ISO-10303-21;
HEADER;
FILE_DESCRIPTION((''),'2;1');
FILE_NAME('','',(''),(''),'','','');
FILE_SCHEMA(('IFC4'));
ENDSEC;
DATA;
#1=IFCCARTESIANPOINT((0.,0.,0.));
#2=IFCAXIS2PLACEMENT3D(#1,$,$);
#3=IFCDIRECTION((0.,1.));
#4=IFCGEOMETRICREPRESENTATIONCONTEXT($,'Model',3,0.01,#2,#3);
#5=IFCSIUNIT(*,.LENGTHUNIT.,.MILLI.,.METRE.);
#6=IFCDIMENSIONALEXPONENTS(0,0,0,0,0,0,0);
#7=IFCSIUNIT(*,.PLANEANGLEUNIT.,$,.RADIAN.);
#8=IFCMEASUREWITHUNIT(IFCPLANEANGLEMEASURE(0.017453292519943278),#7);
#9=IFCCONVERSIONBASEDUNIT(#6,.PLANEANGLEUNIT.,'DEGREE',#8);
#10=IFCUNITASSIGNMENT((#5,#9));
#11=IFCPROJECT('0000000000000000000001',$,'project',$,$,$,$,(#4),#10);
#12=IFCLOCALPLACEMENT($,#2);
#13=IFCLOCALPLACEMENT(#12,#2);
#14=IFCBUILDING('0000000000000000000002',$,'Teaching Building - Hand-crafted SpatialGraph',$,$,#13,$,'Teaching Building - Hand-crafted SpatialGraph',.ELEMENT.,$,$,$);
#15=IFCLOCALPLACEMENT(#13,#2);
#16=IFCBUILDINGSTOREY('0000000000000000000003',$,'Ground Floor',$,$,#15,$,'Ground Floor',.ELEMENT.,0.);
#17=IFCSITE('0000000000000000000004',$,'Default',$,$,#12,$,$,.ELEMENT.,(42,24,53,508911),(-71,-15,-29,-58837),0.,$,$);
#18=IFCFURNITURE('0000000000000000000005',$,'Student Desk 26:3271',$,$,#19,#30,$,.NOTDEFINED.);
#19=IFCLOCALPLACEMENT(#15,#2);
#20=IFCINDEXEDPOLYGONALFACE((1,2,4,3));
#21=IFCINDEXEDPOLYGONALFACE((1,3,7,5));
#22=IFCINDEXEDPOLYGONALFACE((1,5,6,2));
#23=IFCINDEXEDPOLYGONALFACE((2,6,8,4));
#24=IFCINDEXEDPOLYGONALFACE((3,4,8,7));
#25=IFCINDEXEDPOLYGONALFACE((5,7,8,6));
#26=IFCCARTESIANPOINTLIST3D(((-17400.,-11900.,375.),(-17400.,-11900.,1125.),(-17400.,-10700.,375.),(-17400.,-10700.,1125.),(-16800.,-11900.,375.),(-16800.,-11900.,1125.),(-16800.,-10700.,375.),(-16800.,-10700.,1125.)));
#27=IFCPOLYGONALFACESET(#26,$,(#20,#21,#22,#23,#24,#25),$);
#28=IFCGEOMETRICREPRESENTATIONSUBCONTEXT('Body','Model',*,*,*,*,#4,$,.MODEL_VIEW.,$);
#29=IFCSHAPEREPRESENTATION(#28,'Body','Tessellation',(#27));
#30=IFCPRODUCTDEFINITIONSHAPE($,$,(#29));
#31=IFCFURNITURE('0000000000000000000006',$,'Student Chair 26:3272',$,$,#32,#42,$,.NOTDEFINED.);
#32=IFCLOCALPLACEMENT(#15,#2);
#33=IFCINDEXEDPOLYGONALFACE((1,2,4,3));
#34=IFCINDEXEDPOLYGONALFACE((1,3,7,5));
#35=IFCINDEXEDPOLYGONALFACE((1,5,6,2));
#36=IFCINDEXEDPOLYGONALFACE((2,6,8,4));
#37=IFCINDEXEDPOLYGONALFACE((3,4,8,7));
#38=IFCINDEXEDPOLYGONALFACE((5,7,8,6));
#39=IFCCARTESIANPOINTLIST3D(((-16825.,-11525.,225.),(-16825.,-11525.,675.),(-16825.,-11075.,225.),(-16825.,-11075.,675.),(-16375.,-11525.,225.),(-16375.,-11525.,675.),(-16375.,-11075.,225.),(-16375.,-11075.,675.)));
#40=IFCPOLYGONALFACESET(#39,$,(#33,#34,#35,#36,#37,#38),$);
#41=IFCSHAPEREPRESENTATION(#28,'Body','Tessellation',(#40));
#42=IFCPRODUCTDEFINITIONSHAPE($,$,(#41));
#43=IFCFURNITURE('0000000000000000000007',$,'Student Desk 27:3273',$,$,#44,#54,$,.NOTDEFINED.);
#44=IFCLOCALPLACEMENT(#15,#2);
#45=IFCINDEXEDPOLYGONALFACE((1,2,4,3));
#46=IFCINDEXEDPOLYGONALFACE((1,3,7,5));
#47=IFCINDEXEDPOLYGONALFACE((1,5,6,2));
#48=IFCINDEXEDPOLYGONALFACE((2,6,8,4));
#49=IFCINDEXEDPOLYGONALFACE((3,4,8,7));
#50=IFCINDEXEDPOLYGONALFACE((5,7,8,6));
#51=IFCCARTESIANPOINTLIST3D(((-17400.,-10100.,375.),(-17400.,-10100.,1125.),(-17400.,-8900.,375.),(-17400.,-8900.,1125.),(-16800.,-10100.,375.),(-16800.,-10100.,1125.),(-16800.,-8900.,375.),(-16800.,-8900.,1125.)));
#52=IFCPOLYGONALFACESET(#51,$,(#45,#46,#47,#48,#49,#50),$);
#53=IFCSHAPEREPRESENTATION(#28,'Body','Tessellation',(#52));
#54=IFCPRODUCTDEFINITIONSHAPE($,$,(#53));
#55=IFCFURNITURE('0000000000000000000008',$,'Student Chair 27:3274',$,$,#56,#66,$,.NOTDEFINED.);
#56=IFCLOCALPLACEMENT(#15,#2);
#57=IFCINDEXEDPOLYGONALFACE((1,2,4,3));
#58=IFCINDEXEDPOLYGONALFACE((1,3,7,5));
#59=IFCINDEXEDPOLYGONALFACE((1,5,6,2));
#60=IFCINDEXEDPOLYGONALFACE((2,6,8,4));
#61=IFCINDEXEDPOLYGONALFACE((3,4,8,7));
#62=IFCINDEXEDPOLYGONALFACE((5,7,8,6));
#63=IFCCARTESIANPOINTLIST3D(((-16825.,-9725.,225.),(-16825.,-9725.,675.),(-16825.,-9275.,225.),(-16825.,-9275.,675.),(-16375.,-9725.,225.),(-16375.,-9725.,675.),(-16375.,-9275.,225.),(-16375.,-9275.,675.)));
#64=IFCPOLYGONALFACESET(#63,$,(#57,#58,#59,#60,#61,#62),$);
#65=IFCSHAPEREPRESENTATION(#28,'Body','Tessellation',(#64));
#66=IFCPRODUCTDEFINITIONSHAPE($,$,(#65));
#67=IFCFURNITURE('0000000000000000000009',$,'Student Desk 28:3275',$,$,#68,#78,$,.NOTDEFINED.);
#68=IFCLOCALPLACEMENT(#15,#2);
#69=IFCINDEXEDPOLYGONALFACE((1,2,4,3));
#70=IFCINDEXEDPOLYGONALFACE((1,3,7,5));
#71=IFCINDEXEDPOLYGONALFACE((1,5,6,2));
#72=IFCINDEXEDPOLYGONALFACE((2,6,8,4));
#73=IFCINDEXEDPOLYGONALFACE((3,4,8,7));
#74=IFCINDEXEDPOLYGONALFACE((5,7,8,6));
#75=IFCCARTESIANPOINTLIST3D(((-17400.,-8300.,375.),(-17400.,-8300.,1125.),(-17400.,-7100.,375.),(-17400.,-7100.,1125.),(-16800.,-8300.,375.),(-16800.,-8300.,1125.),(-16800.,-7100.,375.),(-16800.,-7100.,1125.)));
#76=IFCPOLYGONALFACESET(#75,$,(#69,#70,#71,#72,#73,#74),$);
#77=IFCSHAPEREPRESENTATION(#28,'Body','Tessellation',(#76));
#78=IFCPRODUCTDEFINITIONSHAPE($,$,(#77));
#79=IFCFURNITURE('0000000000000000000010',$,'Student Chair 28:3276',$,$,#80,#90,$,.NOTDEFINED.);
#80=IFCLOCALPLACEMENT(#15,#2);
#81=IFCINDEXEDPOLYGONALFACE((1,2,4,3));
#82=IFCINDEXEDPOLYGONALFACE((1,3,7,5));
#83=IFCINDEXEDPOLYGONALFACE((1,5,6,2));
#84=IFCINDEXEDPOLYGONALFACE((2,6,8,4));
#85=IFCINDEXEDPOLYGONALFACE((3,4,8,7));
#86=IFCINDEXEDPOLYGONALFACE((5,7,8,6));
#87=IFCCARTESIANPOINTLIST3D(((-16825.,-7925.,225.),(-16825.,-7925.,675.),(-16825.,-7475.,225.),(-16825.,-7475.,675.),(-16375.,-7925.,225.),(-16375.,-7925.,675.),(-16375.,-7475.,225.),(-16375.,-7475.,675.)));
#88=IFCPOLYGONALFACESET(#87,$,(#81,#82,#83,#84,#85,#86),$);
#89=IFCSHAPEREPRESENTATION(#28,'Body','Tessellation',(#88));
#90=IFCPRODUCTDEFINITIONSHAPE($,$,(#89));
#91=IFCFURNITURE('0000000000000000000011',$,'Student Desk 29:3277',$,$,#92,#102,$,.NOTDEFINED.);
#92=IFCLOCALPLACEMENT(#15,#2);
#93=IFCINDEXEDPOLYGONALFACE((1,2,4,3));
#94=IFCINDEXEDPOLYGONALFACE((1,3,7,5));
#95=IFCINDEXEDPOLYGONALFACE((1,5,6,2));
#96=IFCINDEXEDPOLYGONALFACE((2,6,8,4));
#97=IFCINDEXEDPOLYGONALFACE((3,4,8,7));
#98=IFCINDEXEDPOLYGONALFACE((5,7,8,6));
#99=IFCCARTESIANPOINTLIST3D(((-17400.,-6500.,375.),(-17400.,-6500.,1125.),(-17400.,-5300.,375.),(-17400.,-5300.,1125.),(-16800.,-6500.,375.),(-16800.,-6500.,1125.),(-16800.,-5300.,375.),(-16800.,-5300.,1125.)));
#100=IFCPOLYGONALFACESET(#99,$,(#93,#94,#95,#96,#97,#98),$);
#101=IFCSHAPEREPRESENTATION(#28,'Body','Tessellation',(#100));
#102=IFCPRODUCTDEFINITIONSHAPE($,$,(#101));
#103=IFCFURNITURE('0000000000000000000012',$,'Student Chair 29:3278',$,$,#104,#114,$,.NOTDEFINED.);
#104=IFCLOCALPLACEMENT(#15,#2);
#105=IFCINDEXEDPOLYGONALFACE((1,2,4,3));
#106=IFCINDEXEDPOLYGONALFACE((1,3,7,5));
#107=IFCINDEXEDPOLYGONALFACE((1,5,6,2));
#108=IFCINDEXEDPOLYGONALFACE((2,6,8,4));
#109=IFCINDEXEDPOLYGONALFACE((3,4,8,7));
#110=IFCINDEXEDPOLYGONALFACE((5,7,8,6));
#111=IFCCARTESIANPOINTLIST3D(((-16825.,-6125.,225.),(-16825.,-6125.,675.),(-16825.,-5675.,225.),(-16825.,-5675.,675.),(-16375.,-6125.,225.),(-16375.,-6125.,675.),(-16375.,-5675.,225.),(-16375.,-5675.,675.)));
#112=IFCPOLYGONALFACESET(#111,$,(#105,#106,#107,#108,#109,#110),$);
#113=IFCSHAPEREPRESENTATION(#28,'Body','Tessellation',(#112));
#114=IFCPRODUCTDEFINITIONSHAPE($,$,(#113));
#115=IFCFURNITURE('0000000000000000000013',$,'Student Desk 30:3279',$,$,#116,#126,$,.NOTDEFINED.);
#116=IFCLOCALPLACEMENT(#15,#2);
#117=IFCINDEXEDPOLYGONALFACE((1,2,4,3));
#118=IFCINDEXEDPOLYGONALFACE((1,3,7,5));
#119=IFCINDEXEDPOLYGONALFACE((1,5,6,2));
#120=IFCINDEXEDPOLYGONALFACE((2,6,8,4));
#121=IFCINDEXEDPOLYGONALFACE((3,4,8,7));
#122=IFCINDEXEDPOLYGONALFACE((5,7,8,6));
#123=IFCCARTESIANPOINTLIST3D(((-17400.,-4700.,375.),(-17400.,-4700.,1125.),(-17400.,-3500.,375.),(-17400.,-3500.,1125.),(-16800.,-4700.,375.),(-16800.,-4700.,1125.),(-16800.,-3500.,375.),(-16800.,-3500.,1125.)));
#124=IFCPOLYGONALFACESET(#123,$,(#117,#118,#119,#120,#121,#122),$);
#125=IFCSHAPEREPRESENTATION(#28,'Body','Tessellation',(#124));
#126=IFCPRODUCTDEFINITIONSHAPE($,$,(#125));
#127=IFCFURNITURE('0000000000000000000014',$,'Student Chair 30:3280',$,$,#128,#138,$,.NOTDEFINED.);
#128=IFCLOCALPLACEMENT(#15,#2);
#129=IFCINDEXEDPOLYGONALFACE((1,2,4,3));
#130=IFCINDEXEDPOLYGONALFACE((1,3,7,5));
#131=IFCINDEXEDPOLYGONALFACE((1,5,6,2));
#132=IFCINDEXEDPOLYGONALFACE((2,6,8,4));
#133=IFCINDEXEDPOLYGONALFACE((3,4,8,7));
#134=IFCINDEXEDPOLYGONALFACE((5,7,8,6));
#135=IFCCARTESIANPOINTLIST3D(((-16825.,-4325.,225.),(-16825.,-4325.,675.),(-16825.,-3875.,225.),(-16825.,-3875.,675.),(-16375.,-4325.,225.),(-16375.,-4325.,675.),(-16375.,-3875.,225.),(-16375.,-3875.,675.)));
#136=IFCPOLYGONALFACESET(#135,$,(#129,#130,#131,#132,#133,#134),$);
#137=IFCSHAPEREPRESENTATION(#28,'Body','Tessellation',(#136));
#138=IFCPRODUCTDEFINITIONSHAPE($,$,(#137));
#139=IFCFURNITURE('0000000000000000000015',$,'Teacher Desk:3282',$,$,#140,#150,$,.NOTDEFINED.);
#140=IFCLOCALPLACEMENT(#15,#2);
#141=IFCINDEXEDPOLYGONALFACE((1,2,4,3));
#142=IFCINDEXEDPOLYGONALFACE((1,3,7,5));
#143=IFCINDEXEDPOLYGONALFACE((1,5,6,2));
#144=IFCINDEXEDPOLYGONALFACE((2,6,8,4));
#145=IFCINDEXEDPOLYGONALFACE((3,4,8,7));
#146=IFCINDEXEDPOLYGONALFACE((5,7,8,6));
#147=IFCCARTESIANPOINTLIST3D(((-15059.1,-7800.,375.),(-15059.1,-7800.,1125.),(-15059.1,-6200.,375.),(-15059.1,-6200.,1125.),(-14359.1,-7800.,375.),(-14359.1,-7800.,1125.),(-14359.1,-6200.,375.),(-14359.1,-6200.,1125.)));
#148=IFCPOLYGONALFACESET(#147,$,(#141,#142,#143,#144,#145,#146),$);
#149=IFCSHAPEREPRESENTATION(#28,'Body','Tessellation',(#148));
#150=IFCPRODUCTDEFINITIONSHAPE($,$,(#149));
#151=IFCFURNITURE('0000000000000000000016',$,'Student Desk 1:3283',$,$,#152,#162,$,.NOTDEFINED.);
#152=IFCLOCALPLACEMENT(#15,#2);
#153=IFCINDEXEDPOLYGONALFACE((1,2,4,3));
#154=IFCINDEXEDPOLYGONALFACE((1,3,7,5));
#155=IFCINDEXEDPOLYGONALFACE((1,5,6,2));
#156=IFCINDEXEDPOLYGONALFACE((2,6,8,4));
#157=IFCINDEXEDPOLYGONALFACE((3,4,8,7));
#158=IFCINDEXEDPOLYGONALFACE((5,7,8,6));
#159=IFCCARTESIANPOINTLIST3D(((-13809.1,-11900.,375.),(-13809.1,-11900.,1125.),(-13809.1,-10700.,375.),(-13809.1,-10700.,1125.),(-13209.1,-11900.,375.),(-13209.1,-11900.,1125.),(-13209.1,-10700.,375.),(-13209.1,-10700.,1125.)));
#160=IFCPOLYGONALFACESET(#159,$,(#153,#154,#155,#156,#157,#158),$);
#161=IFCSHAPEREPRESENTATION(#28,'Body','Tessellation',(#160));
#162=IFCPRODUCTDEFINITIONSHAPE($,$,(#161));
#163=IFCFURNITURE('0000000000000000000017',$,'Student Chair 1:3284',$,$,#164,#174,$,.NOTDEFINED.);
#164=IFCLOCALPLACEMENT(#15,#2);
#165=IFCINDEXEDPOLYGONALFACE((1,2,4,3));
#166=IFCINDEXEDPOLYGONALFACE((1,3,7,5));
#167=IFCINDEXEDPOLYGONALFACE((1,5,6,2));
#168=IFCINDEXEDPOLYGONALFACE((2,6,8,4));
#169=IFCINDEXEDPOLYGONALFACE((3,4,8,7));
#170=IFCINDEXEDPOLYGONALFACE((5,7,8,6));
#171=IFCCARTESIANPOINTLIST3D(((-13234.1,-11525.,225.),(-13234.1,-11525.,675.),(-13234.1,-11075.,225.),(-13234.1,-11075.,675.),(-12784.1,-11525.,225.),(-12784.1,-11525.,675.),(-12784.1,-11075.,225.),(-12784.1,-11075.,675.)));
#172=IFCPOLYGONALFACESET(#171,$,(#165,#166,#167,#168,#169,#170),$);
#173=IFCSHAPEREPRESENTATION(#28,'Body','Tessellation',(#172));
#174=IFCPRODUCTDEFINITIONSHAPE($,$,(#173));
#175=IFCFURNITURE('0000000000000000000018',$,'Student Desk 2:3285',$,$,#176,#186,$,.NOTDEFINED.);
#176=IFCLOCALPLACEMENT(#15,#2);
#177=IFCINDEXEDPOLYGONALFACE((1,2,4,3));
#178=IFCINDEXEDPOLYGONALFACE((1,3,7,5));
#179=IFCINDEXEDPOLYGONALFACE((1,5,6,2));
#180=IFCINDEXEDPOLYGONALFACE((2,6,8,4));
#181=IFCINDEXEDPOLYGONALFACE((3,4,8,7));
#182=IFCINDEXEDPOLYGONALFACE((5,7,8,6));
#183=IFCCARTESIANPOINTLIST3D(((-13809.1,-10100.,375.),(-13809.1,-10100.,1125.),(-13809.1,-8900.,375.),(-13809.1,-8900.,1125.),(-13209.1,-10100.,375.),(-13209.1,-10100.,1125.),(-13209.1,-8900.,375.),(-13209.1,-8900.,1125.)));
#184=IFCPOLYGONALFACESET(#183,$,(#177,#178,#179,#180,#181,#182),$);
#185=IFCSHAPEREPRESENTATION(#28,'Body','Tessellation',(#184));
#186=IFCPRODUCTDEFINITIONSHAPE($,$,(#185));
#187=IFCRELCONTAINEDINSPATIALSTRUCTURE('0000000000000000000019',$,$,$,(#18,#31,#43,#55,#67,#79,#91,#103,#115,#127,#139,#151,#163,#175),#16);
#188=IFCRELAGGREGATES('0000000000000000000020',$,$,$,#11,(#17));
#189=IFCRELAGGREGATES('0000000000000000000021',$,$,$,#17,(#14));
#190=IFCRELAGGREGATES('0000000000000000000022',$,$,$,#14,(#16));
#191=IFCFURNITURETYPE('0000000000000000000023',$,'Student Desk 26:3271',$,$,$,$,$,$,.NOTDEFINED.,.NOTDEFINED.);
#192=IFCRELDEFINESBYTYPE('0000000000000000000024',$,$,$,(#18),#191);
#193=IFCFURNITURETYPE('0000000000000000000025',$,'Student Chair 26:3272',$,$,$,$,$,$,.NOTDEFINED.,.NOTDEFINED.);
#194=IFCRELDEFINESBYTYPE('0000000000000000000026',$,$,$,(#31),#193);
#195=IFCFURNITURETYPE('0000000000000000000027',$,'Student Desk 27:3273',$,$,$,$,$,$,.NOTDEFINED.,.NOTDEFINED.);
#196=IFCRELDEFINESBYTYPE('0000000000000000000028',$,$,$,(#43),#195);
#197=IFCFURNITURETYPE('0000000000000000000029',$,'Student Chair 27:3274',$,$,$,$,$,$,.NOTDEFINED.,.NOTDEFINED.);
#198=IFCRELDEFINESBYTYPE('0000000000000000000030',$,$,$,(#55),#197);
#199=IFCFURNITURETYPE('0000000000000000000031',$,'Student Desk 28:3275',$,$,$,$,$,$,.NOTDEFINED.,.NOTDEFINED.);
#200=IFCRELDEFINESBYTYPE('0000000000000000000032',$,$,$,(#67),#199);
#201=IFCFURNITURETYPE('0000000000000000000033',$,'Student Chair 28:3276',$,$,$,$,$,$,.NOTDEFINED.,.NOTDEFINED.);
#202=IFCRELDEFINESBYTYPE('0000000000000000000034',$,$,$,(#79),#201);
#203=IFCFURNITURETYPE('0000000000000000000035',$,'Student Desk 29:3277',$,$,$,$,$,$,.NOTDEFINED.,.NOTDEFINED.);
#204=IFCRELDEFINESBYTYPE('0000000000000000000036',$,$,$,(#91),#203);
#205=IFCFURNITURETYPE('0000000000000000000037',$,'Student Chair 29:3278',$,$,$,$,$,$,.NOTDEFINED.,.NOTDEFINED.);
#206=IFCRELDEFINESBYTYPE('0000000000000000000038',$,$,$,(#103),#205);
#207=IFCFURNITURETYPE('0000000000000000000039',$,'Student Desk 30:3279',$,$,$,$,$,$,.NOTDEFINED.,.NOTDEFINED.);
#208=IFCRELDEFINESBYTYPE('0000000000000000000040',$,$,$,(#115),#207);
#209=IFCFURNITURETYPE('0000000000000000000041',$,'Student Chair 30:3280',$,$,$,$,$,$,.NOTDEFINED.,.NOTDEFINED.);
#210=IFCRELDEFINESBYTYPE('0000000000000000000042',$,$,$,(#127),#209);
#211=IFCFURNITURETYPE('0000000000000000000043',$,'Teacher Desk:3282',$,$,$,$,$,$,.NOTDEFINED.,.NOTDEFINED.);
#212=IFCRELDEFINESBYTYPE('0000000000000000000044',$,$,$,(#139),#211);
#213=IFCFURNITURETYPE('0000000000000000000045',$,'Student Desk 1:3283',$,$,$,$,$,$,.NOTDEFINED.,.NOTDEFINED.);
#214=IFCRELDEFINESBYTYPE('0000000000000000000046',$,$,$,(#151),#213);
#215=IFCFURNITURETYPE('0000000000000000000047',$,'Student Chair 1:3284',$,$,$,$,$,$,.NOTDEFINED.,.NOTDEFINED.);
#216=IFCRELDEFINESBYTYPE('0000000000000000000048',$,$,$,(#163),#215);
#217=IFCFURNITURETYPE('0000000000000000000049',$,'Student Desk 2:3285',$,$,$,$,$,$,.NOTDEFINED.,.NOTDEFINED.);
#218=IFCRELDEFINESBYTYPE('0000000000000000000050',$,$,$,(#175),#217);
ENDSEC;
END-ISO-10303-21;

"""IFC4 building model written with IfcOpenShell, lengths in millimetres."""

from ifc_helpers import new_model, entity, si_unit, converted_unit, direction, frame, frame_2d, origin, origin_2d_with_axis, place, context, subcontext, project, spatial, rectangle, extrude, type_object, element, save


model = new_model("IFC4")

# Units and contexts
model_context = context("Model", 3, precision=0.01, world=origin(), true_north=direction((0.0, 1.0)))
body_context = subcontext(model_context, "Body", "Model", "MODEL_VIEW")
ifc_project = project(units=[si_unit("LENGTHUNIT", "METRE", prefix="MILLI"), converted_unit("PLANEANGLEUNIT", "DEGREE", entity("IfcPlaneAngleMeasure", 0.017453292519943278), si_unit("PLANEANGLEUNIT", "RADIAN"), dimensions=[0, 0, 0, 0, 0, 0, 0])], contexts=[model_context])

# Site, building, storey
site_placement = place(None, origin())
site = spatial("IfcSite", under=ifc_project, at=site_placement, Name="Default", CompositionType="ELEMENT", RefLatitude=(42, 24, 53, 508911), RefLongitude=(-71, -15, -29, -58837), RefElevation=0.0)
building_placement = place(site_placement, origin())
building = spatial("IfcBuilding", under=site, at=building_placement, Name="Teaching Building - Hand-crafted SpatialGraph", LongName="Teaching Building - Hand-crafted SpatialGraph", CompositionType="ELEMENT")
storey_placement = place(building_placement, origin())
storey = spatial("IfcBuildingStorey", under=building, at=storey_placement, Name="Ground Floor", LongName="Ground Floor", CompositionType="ELEMENT", Elevation=0.0)

# Furniture
furniture_type_1 = type_object("IfcFurnitureType", Name="Student Desk 26:3271", PredefinedType="NOTDEFINED")
furniture_1_placement = place(storey_placement, origin())
element("IfcFurniture", 1, at=furniture_1_placement, inside=storey, type_object=furniture_type_1, Name="Student Desk 26:3271", PredefinedType="NOTDEFINED", context=body_context, shape_type="SweptSolid", body=[
    extrude(rectangle(XDim=1200.0, YDim=600.0, at=frame_2d((0.0, 0.0), x_axis=(1.0, 0.0))), frame((-17100.0, -11300.0, 375.0), z_axis=(0.0, 0.0, 1.0), x_axis=(0.0, 1.0, 0.0)), (0.0, 0.0, 1.0), 750.0),
])
furniture_type_2 = type_object("IfcFurnitureType", Name="Student Chair 26:3272", PredefinedType="NOTDEFINED")
furniture_2_placement = place(storey_placement, origin())
element("IfcFurniture", 2, at=furniture_2_placement, inside=storey, type_object=furniture_type_2, Name="Student Chair 26:3272", PredefinedType="NOTDEFINED", context=body_context, shape_type="SweptSolid", body=[
    extrude(rectangle(XDim=450.0, YDim=450.0, at=origin_2d_with_axis()), frame((-16600.0, -11300.0, 225.0)), (0.0, 0.0, 1.0), 450.0),
])
furniture_type_3 = type_object("IfcFurnitureType", Name="Student Desk 27:3273", PredefinedType="NOTDEFINED")
furniture_3_placement = place(storey_placement, origin())
element("IfcFurniture", 3, at=furniture_3_placement, inside=storey, type_object=furniture_type_3, Name="Student Desk 27:3273", PredefinedType="NOTDEFINED", context=body_context, shape_type="SweptSolid", body=[
    extrude(rectangle(XDim=1200.0, YDim=600.0, at=frame_2d((0.0, 0.0), x_axis=(1.0, 0.0))), frame((-17100.0, -9500.0, 375.0), z_axis=(0.0, 0.0, 1.0), x_axis=(0.0, 1.0, 0.0)), (0.0, 0.0, 1.0), 750.0),
])
furniture_type_4 = type_object("IfcFurnitureType", Name="Student Chair 27:3274", PredefinedType="NOTDEFINED")
furniture_4_placement = place(storey_placement, origin())
element("IfcFurniture", 4, at=furniture_4_placement, inside=storey, type_object=furniture_type_4, Name="Student Chair 27:3274", PredefinedType="NOTDEFINED", context=body_context, shape_type="SweptSolid", body=[
    extrude(rectangle(XDim=450.0, YDim=450.0, at=origin_2d_with_axis()), frame((-16600.0, -9500.0, 225.0)), (0.0, 0.0, 1.0), 450.0),
])
furniture_type_5 = type_object("IfcFurnitureType", Name="Student Desk 28:3275", PredefinedType="NOTDEFINED")
furniture_5_placement = place(storey_placement, origin())
element("IfcFurniture", 5, at=furniture_5_placement, inside=storey, type_object=furniture_type_5, Name="Student Desk 28:3275", PredefinedType="NOTDEFINED", context=body_context, shape_type="SweptSolid", body=[
    extrude(rectangle(XDim=1200.0, YDim=600.0, at=frame_2d((0.0, 0.0), x_axis=(1.0, 0.0))), frame((-17100.0, -7700.0, 375.0), z_axis=(0.0, 0.0, 1.0), x_axis=(0.0, 1.0, 0.0)), (0.0, 0.0, 1.0), 750.0),
])
furniture_type_6 = type_object("IfcFurnitureType", Name="Student Chair 28:3276", PredefinedType="NOTDEFINED")
furniture_6_placement = place(storey_placement, origin())
element("IfcFurniture", 6, at=furniture_6_placement, inside=storey, type_object=furniture_type_6, Name="Student Chair 28:3276", PredefinedType="NOTDEFINED", context=body_context, shape_type="SweptSolid", body=[
    extrude(rectangle(XDim=450.0, YDim=450.0, at=frame_2d((0.0, 0.0), x_axis=(1.0, 0.0))), frame((-16600.0, -7700.0, 225.0)), (0.0, 0.0, 1.0), 450.0),
])
furniture_type_7 = type_object("IfcFurnitureType", Name="Student Desk 29:3277", PredefinedType="NOTDEFINED")
furniture_7_placement = place(storey_placement, origin())
element("IfcFurniture", 7, at=furniture_7_placement, inside=storey, type_object=furniture_type_7, Name="Student Desk 29:3277", PredefinedType="NOTDEFINED", context=body_context, shape_type="SweptSolid", body=[
    extrude(rectangle(XDim=1200.0, YDim=600.0, at=frame_2d((0.0, 0.0), x_axis=(1.0, 0.0))), frame((-17100.0, -5900.0, 375.0), z_axis=(0.0, 0.0, 1.0), x_axis=(0.0, 1.0, 0.0)), (0.0, 0.0, 1.0), 750.0),
])
furniture_type_8 = type_object("IfcFurnitureType", Name="Student Chair 29:3278", PredefinedType="NOTDEFINED")
furniture_8_placement = place(storey_placement, origin())
element("IfcFurniture", 8, at=furniture_8_placement, inside=storey, type_object=furniture_type_8, Name="Student Chair 29:3278", PredefinedType="NOTDEFINED", context=body_context, shape_type="SweptSolid", body=[
    extrude(rectangle(XDim=450.0, YDim=450.0, at=origin_2d_with_axis()), frame((-16600.0, -5900.0, 225.0)), (0.0, 0.0, 1.0), 450.0),
])
furniture_type_9 = type_object("IfcFurnitureType", Name="Student Desk 30:3279", PredefinedType="NOTDEFINED")
furniture_9_placement = place(storey_placement, origin())
element("IfcFurniture", 9, at=furniture_9_placement, inside=storey, type_object=furniture_type_9, Name="Student Desk 30:3279", PredefinedType="NOTDEFINED", context=body_context, shape_type="SweptSolid", body=[
    extrude(rectangle(XDim=1200.0, YDim=600.0, at=frame_2d((0.0, 0.0), x_axis=(1.0, 0.0))), frame((-17100.0, -4100.0, 375.0), z_axis=(0.0, 0.0, 1.0), x_axis=(0.0, 1.0, 0.0)), (0.0, 0.0, 1.0), 750.0),
])
furniture_type_10 = type_object("IfcFurnitureType", Name="Student Chair 30:3280", PredefinedType="NOTDEFINED")
furniture_10_placement = place(storey_placement, origin())
element("IfcFurniture", 10, at=furniture_10_placement, inside=storey, type_object=furniture_type_10, Name="Student Chair 30:3280", PredefinedType="NOTDEFINED", context=body_context, shape_type="SweptSolid", body=[
    extrude(rectangle(XDim=450.0, YDim=450.0, at=origin_2d_with_axis()), frame((-16600.0, -4100.0, 225.0)), (0.0, 0.0, 1.0), 450.0),
])
furniture_type_11 = type_object("IfcFurnitureType", Name="Teacher Desk:3282", PredefinedType="NOTDEFINED")
furniture_11_placement = place(storey_placement, origin())
element("IfcFurniture", 11, at=furniture_11_placement, inside=storey, type_object=furniture_type_11, Name="Teacher Desk:3282", PredefinedType="NOTDEFINED", context=body_context, shape_type="SweptSolid", body=[
    extrude(rectangle(XDim=1600.0, YDim=700.0, at=origin_2d_with_axis()), frame((-14709.1, -7000.0, 375.0), z_axis=(0.0, 0.0, 1.0), x_axis=(0.0, 1.0, 0.0)), (0.0, 0.0, 1.0), 750.0),
])
furniture_type_12 = type_object("IfcFurnitureType", Name="Student Desk 1:3283", PredefinedType="NOTDEFINED")
furniture_12_placement = place(storey_placement, origin())
element("IfcFurniture", 12, at=furniture_12_placement, inside=storey, type_object=furniture_type_12, Name="Student Desk 1:3283", PredefinedType="NOTDEFINED", context=body_context, shape_type="SweptSolid", body=[
    extrude(rectangle(XDim=1200.0, YDim=600.0, at=origin_2d_with_axis()), frame((-13509.1, -11300.0, 375.0), z_axis=(0.0, 0.0, 1.0), x_axis=(0.0, 1.0, 0.0)), (0.0, 0.0, 1.0), 750.0),
])
furniture_type_13 = type_object("IfcFurnitureType", Name="Student Chair 1:3284", PredefinedType="NOTDEFINED")
furniture_13_placement = place(storey_placement, origin())
element("IfcFurniture", 13, at=furniture_13_placement, inside=storey, type_object=furniture_type_13, Name="Student Chair 1:3284", PredefinedType="NOTDEFINED", context=body_context, shape_type="SweptSolid", body=[
    extrude(rectangle(XDim=450.0, YDim=450.0, at=origin_2d_with_axis()), frame((-13009.1, -11300.0, 225.0)), (0.0, 0.0, 1.0), 450.0),
])
furniture_type_14 = type_object("IfcFurnitureType", Name="Student Desk 2:3285", PredefinedType="NOTDEFINED")
furniture_14_placement = place(storey_placement, origin())
element("IfcFurniture", 14, at=furniture_14_placement, inside=storey, type_object=furniture_type_14, Name="Student Desk 2:3285", PredefinedType="NOTDEFINED", context=body_context, shape_type="SweptSolid", body=[
    extrude(rectangle(XDim=1200.0, YDim=600.0, at=origin_2d_with_axis()), frame((-13509.1, -9500.0, 375.0), z_axis=(0.0, 0.0, 1.0), x_axis=(0.0, 1.0, 0.0)), (0.0, 0.0, 1.0), 750.0),
])

save(model, "model.ifc")
